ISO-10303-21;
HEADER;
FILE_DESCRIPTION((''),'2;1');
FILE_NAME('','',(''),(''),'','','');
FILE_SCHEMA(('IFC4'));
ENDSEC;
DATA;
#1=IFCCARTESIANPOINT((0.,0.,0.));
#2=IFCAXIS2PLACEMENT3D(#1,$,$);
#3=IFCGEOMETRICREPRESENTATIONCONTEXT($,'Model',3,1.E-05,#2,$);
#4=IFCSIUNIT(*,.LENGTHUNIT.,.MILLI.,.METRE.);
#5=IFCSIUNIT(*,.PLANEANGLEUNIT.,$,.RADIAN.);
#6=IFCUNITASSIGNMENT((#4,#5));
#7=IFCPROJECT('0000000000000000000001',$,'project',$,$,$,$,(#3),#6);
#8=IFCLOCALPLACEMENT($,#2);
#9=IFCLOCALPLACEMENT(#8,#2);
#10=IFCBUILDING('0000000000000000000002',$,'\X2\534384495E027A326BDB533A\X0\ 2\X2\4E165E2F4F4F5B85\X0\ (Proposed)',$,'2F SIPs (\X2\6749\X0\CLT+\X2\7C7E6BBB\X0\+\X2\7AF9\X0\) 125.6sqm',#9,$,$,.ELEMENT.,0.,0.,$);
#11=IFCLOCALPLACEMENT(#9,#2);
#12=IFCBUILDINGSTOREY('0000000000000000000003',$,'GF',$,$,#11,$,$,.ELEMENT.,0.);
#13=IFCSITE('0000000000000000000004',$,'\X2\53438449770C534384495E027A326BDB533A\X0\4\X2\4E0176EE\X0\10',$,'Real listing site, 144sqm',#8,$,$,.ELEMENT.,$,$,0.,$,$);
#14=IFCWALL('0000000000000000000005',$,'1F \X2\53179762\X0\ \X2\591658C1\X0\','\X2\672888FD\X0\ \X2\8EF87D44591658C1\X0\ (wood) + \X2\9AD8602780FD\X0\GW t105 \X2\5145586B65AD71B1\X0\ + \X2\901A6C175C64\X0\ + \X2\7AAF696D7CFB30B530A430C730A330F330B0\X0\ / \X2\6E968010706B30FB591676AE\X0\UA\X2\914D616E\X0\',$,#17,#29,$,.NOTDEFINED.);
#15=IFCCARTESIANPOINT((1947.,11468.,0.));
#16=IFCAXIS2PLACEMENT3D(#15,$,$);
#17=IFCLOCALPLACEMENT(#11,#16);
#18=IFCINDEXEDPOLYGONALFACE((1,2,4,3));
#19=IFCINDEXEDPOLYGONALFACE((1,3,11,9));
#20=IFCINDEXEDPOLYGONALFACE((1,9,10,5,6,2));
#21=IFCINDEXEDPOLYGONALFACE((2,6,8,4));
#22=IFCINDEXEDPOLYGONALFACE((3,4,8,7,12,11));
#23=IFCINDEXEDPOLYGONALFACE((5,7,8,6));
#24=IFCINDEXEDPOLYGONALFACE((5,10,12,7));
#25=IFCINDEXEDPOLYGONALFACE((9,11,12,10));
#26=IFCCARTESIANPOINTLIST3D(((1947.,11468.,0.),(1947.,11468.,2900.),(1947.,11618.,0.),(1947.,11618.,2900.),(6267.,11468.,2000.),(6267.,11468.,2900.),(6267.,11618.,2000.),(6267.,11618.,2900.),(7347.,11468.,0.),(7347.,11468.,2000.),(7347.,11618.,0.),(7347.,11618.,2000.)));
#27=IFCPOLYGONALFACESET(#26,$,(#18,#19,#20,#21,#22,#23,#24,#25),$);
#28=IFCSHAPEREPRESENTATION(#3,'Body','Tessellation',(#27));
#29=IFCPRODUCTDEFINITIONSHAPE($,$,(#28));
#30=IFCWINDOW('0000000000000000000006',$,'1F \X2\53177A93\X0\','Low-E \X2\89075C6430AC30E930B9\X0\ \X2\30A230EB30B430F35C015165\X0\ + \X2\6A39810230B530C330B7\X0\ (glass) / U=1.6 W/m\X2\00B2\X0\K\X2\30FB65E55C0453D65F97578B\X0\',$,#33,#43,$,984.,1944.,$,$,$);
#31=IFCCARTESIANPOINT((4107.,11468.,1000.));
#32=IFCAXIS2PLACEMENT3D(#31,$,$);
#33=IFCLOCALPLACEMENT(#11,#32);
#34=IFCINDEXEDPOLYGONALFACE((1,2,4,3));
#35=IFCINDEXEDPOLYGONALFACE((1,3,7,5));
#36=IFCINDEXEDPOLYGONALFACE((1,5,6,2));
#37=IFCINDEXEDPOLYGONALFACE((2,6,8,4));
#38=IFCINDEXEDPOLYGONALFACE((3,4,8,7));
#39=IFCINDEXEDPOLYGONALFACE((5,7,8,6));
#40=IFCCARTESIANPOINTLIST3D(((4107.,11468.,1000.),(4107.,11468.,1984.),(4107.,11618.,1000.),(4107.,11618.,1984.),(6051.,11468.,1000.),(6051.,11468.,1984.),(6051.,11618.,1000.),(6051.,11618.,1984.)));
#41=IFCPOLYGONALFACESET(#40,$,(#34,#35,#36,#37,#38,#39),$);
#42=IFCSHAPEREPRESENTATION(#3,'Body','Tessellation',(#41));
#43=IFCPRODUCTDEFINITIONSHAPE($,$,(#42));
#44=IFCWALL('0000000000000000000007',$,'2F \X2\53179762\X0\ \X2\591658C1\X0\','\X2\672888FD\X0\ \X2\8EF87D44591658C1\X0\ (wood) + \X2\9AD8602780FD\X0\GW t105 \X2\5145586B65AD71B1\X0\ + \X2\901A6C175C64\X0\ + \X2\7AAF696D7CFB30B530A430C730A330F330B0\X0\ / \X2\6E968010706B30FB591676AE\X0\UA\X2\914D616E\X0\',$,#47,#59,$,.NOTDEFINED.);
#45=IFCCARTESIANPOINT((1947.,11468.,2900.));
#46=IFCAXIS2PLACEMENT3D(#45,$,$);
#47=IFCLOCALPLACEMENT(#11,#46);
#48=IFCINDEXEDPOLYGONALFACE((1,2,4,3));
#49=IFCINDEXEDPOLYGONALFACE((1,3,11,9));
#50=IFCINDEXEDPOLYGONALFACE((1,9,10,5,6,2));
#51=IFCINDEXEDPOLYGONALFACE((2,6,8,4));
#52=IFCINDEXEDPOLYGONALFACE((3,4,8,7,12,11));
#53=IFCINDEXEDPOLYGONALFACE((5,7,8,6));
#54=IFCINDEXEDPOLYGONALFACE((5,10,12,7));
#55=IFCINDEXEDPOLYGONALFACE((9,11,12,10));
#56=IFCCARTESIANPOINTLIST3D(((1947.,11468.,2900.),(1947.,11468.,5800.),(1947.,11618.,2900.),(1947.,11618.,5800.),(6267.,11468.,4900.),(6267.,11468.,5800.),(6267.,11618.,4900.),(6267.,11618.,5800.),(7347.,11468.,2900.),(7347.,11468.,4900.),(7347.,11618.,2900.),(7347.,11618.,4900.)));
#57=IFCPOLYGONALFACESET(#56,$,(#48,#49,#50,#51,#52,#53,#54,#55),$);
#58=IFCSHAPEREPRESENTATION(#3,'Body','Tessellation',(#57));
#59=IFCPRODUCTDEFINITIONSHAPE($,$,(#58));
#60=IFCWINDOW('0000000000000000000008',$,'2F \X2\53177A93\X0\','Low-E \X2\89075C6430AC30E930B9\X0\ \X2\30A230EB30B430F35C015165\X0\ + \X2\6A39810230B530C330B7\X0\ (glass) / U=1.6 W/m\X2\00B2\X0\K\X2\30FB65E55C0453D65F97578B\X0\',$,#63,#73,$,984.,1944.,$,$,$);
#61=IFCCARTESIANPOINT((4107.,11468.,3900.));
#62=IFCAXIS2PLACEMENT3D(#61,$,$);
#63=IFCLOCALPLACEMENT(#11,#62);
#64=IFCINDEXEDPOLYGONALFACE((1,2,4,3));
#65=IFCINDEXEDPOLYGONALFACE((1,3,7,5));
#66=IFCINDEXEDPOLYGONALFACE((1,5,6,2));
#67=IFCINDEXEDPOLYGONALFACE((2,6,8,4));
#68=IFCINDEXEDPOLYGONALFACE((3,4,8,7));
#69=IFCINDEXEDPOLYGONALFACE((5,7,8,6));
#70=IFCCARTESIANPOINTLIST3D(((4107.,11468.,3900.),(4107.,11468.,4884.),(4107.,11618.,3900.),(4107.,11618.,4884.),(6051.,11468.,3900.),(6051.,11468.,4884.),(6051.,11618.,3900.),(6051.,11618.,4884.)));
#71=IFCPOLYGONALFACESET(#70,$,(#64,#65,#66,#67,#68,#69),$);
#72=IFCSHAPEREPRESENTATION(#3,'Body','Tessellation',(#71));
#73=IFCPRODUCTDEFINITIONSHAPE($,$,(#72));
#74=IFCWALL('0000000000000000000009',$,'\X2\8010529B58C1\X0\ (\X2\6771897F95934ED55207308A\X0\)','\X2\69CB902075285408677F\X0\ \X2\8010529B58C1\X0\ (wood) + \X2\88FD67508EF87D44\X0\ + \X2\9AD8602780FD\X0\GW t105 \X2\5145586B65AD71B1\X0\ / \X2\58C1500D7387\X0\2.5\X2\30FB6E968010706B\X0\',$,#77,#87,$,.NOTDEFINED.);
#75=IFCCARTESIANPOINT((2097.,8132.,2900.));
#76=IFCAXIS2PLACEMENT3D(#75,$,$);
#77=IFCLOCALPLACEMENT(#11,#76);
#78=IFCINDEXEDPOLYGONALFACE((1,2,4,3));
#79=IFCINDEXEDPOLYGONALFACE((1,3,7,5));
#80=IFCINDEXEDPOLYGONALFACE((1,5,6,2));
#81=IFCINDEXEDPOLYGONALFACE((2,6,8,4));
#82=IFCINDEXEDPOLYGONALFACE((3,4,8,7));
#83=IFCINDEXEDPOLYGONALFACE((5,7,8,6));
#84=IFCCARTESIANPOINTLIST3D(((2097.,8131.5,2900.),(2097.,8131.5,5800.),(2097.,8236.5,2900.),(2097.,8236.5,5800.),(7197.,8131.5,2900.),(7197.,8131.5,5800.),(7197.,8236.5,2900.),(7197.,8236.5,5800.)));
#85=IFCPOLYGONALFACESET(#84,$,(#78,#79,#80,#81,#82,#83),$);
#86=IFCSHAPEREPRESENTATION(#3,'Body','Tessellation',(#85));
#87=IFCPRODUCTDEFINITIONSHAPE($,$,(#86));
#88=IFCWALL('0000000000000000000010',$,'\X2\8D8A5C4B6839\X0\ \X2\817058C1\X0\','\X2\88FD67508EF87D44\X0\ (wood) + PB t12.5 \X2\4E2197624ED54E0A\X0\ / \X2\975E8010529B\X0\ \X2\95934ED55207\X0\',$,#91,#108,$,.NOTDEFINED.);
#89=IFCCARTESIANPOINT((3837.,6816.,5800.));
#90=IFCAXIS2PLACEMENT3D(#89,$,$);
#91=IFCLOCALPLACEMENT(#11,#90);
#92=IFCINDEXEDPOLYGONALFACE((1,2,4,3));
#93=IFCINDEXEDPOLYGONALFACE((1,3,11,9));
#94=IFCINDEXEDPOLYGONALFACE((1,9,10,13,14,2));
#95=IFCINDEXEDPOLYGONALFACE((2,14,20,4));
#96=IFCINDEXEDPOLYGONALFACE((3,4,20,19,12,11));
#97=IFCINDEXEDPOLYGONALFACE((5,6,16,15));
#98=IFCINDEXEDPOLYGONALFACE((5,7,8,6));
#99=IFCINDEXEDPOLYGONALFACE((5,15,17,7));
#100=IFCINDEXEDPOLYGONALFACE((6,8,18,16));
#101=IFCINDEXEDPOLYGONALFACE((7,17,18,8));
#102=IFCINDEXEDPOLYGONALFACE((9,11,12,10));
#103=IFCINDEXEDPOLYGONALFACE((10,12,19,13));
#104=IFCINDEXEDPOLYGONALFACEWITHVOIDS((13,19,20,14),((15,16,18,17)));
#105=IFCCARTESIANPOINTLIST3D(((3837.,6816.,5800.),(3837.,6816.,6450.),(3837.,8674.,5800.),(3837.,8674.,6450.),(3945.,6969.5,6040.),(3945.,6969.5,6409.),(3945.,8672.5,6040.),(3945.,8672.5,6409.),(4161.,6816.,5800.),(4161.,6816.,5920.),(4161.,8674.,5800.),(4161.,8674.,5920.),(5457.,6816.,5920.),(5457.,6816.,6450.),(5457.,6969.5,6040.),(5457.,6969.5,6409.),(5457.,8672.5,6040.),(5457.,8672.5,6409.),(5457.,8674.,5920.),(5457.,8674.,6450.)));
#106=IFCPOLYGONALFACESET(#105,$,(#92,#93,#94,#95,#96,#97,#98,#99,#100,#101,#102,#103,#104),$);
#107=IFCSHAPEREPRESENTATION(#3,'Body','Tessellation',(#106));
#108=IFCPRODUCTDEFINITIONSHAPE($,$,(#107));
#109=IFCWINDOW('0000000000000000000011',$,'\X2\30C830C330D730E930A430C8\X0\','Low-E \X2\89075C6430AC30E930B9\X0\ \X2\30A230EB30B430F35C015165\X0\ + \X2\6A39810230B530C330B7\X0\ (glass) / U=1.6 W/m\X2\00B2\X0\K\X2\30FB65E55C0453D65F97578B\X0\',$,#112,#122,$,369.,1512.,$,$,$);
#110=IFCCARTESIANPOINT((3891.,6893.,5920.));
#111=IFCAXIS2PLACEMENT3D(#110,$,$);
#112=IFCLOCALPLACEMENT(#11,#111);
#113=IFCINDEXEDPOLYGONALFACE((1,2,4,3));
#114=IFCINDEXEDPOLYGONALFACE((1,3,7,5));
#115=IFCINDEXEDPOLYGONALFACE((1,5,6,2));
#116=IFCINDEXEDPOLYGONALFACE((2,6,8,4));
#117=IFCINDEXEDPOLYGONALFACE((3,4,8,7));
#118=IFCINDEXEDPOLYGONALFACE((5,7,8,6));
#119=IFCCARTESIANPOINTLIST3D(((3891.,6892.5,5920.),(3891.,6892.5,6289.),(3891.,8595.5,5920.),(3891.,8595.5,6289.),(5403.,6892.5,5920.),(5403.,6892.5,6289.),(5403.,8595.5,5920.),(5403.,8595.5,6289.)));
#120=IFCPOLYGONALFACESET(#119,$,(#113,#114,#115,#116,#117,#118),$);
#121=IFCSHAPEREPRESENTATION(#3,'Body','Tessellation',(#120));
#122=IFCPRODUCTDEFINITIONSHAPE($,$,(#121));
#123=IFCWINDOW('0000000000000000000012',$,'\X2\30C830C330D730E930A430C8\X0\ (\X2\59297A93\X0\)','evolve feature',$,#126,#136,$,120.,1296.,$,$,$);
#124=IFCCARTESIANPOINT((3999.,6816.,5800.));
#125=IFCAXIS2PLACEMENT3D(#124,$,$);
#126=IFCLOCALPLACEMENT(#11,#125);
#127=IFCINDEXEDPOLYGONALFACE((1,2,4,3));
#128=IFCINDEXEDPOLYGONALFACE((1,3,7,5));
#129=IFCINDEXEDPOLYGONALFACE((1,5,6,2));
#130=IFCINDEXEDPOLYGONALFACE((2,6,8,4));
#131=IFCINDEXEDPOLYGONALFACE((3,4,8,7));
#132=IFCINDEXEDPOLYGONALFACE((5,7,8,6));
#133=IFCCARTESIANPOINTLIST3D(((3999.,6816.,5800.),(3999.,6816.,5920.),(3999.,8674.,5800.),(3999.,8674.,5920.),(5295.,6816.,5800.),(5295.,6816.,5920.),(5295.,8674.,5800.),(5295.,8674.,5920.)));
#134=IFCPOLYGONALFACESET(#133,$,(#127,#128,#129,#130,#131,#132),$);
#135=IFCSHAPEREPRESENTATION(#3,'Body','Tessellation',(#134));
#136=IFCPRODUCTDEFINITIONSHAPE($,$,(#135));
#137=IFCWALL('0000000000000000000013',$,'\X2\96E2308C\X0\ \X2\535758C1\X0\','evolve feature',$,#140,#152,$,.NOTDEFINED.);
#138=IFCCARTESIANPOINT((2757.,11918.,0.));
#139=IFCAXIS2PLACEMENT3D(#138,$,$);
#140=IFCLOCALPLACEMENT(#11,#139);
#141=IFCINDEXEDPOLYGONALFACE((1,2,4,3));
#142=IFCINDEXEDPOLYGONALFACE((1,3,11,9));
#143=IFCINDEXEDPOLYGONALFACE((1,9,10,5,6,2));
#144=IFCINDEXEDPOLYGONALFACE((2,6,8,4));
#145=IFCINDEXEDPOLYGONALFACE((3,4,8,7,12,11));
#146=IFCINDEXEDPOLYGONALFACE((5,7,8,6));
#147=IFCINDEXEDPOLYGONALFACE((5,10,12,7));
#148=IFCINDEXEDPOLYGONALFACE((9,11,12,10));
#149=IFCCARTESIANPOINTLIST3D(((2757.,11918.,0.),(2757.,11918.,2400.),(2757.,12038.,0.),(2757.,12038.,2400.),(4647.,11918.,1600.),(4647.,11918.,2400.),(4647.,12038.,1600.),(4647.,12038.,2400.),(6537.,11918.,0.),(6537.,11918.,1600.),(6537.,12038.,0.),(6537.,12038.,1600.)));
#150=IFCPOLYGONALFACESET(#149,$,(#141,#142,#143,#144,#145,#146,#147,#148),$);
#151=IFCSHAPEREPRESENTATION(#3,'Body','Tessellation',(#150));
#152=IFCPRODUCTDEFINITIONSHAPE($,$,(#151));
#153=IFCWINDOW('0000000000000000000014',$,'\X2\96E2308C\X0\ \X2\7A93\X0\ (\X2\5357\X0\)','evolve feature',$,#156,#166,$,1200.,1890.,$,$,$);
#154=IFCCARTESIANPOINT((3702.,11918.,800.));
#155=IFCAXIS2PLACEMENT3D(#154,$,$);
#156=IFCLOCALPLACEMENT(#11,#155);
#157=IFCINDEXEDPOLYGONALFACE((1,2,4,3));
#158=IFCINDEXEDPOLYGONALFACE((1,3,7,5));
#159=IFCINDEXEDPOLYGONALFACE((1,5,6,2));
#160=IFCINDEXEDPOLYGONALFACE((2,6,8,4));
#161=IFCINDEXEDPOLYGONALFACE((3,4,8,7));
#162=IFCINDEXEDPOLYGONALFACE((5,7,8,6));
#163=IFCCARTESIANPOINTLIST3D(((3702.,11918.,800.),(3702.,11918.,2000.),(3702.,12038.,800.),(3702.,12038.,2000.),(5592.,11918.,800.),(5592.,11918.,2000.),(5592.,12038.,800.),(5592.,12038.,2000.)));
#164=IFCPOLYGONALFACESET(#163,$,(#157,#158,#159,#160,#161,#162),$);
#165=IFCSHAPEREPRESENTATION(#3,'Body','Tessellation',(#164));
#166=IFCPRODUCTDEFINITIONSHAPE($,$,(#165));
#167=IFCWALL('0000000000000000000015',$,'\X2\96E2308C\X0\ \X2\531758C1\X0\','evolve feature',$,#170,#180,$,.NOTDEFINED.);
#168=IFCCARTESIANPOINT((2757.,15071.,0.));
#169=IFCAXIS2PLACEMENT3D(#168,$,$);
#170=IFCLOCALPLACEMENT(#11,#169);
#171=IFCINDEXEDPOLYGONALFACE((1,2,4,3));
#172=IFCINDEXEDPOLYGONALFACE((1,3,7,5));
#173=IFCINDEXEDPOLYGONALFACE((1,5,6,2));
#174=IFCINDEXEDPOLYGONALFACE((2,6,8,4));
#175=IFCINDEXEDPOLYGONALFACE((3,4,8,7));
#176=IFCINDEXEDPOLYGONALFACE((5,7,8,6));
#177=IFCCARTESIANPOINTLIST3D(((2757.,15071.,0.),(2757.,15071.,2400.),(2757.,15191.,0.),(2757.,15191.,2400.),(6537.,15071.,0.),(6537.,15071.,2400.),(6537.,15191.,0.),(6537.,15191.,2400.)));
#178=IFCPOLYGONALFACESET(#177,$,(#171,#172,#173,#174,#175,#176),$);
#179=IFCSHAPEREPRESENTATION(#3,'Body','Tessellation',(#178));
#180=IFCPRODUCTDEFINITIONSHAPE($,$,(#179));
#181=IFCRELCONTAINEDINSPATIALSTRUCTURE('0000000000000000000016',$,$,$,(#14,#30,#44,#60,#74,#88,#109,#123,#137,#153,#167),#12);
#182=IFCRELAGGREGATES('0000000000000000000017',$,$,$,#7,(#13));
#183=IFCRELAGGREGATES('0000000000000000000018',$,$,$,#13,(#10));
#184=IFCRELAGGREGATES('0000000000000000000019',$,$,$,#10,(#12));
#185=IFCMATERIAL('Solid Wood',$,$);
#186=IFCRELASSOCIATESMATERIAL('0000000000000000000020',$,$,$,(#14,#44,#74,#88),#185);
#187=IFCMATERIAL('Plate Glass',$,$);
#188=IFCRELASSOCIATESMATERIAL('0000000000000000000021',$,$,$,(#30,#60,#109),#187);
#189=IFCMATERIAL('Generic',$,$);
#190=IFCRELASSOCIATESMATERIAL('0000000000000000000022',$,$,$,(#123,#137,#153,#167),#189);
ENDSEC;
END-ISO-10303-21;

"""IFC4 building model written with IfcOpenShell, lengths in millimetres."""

from ifc_helpers import new_model, si_unit, frame, frame_2d, origin, place, context, project, spatial, rectangle, extrude, material, element, fill, save


model = new_model("IFC4")

# Units and contexts
model_context = context("Model", 3, precision=1e-05, world=origin())
ifc_project = project(units=[si_unit("LENGTHUNIT", "METRE", prefix="MILLI"), si_unit("PLANEANGLEUNIT", "RADIAN")], contexts=[model_context])

# Site, building, storey
site_placement = place(None, origin())
site = spatial("IfcSite", under=ifc_project, at=site_placement, Name="千葉県千葉市稲毛区4丁目10", ObjectType="Real listing site, 144sqm", CompositionType="ELEMENT", RefElevation=0.0)
building_placement = place(site_placement, origin())
building = spatial("IfcBuilding", under=site, at=building_placement, Name="千葉市稲毛区 2世帯住宅 (Proposed)", ObjectType="2F SIPs (杉CLT+籾殻+竹) 125.6sqm", CompositionType="ELEMENT", ElevationOfRefHeight=0.0, ElevationOfTerrain=0.0)
storey_placement = place(building_placement, origin())
storey = spatial("IfcBuildingStorey", under=building, at=storey_placement, Name="GF", CompositionType="ELEMENT", Elevation=0.0)

# Shared definitions
ifc_material_1 = material(Name="Generic")

# Wall, opening, window
ifc_material_2 = material(Name="Solid Wood")
wall_1_placement = place(storey_placement, frame((1947.0, 11468.0, 0.0)))
wall_1 = element("IfcWall", 1, at=wall_1_placement, inside=storey, material=ifc_material_2, Name="1F 北面 外壁", Description="木製 軸組外壁 (wood) + 高性能GW t105 充填断熱 + 通気層 + 窯業系サイディング / 準耐火・外皮UA配慮", PredefinedType="NOTDEFINED", context=model_context, shape_type="SweptSolid", body=[
    extrude(rectangle(XDim=5400.0, YDim=150.0, at=frame_2d((2700.0, 75.0))), frame((1947.0, 11468.0, 0.0)), (0.0, 0.0, 1.0), 2900.0),
])
opening_1_placement = place(storey_placement, frame((4107.0, 11468.0, 1000.0)))
opening_1 = element("IfcOpeningElement", 2, at=opening_1_placement, cuts=wall_1, PredefinedType="NOTDEFINED", context=model_context, shape_type="SweptSolid", body=[
    extrude(rectangle(XDim=1944.0, YDim=150.0, at=frame_2d((972.0, 75.0))), frame((4107.0, 11468.0, 1000.0)), (0.0, 0.0, 1.0), 984.0),
])
ifc_material_3 = material(Name="Plate Glass")
window_1_placement = place(storey_placement, frame((4107.0, 11468.0, 1000.0)))
window_1 = element("IfcWindow", 3, at=window_1_placement, inside=storey, material=ifc_material_3, Name="1F 北窓", Description="Low-E 複層ガラス アルゴン封入 + 樹脂サッシ (glass) / U=1.6 W/m²K・日射取得型", OverallHeight=984.0, OverallWidth=1944.0, context=model_context, shape_type="SweptSolid", body=[
    extrude(rectangle(XDim=1944.0, YDim=150.0, at=frame_2d((972.0, 75.0))), frame((4107.0, 11468.0, 1000.0)), (0.0, 0.0, 1.0), 984.0),
])
fill(opening_1, window_1)

# Wall, opening, window
wall_2_placement = place(storey_placement, frame((1947.0, 11468.0, 2900.0)))
wall_2 = element("IfcWall", 4, at=wall_2_placement, inside=storey, material=ifc_material_2, Name="2F 北面 外壁", Description="木製 軸組外壁 (wood) + 高性能GW t105 充填断熱 + 通気層 + 窯業系サイディング / 準耐火・外皮UA配慮", PredefinedType="NOTDEFINED", context=model_context, shape_type="SweptSolid", body=[
    extrude(rectangle(XDim=5400.0, YDim=150.0, at=frame_2d((2700.0, 75.0))), frame((1947.0, 11468.0, 2900.0)), (0.0, 0.0, 1.0), 2900.0),
])
opening_2_placement = place(storey_placement, frame((4107.0, 11468.0, 3900.0)))
opening_2 = element("IfcOpeningElement", 5, at=opening_2_placement, cuts=wall_2, PredefinedType="NOTDEFINED", context=model_context, shape_type="SweptSolid", body=[
    extrude(rectangle(XDim=1944.0, YDim=150.0, at=frame_2d((972.0, 75.0))), frame((4107.0, 11468.0, 3900.0)), (0.0, 0.0, 1.0), 984.0),
])
window_2_placement = place(storey_placement, frame((4107.0, 11468.0, 3900.0)))
window_2 = element("IfcWindow", 6, at=window_2_placement, inside=storey, material=ifc_material_3, Name="2F 北窓", Description="Low-E 複層ガラス アルゴン封入 + 樹脂サッシ (glass) / U=1.6 W/m²K・日射取得型", OverallHeight=984.0, OverallWidth=1944.0, context=model_context, shape_type="SweptSolid", body=[
    extrude(rectangle(XDim=1944.0, YDim=150.0, at=frame_2d((972.0, 75.0))), frame((4107.0, 11468.0, 3900.0)), (0.0, 0.0, 1.0), 984.0),
])
fill(opening_2, window_2)

# Wall
wall_3_placement = place(storey_placement, frame((2097.0, 8132.0, 2900.0)))
element("IfcWall", 7, at=wall_3_placement, inside=storey, material=ifc_material_2, Name="耐力壁 (東西間仕切り)", Description="構造用合板 耐力壁 (wood) + 製材軸組 + 高性能GW t105 充填断熱 / 壁倍率2.5・準耐火", PredefinedType="NOTDEFINED", context=model_context, shape_type="SweptSolid", body=[
    extrude(rectangle(XDim=5100.0, YDim=105.0, at=frame_2d((2550.0, 52.0))), frame((2097.0, 8132.0, 2900.0)), (0.0, 0.0, 1.0), 2900.0),
])

# Wall, openings, windows
wall_4_placement = place(storey_placement, frame((3837.0, 6816.0, 5800.0)))
wall_4 = element("IfcWall", 8, at=wall_4_placement, inside=storey, material=ifc_material_2, Name="越屋根 腰壁", Description="製材軸組 (wood) + PB t12.5 両面仕上 / 非耐力 間仕切", PredefinedType="NOTDEFINED", context=model_context, shape_type="SweptSolid", body=[
    extrude(rectangle(XDim=1620.0, YDim=1858.0, at=frame_2d((810.0, 929.0))), frame((3837.0, 6816.0, 5800.0)), (0.0, 0.0, 1.0), 650.0),
])
opening_3_placement = place(storey_placement, frame((3891.0, 6893.0, 5920.0)))
opening_3 = element("IfcOpeningElement", 9, at=opening_3_placement, cuts=wall_4, PredefinedType="NOTDEFINED", context=model_context, shape_type="SweptSolid", body=[
    extrude(rectangle(XDim=1512.0, YDim=1703.0, at=frame_2d((756.0, 851.0))), frame((3891.0, 6893.0, 5920.0)), (0.0, 0.0, 1.0), 369.0),
])
opening_4_placement = place(storey_placement, frame((3999.0, 6816.0, 5800.0)))
opening_4 = element("IfcOpeningElement", 10, at=opening_4_placement, cuts=wall_4, PredefinedType="NOTDEFINED", context=model_context, shape_type="SweptSolid", body=[
    extrude(rectangle(XDim=1296.0, YDim=1858.0, at=frame_2d((648.0, 929.0))), frame((3999.0, 6816.0, 5800.0)), (0.0, 0.0, 1.0), 120.0),
])
window_3_placement = place(storey_placement, frame((3891.0, 6893.0, 5920.0)))
window_3 = element("IfcWindow", 11, at=window_3_placement, inside=storey, material=ifc_material_3, Name="トップライト", Description="Low-E 複層ガラス アルゴン封入 + 樹脂サッシ (glass) / U=1.6 W/m²K・日射取得型", OverallHeight=369.0, OverallWidth=1512.0, context=model_context, shape_type="SweptSolid", body=[
    extrude(rectangle(XDim=1512.0, YDim=1703.0, at=frame_2d((756.0, 851.0))), frame((3891.0, 6893.0, 5920.0)), (0.0, 0.0, 1.0), 369.0),
])
fill(opening_3, window_3)
window_4_placement = place(storey_placement, frame((3999.0, 6816.0, 5800.0)))
window_4 = element("IfcWindow", 12, at=window_4_placement, inside=storey, material=ifc_material_1, Name="トップライト (天窓)", Description="evolve feature", OverallHeight=120.0, OverallWidth=1296.0, context=model_context, shape_type="SweptSolid", body=[
    extrude(rectangle(XDim=1296.0, YDim=1858.0, at=frame_2d((648.0, 929.0))), frame((3999.0, 6816.0, 5800.0)), (0.0, 0.0, 1.0), 120.0),
])
fill(opening_4, window_4)

# Wall, opening, window
wall_5_placement = place(storey_placement, frame((2757.0, 11918.0, 0.0)))
wall_5 = element("IfcWall", 13, at=wall_5_placement, inside=storey, material=ifc_material_1, Name="離れ 南壁", Description="evolve feature", PredefinedType="NOTDEFINED", context=model_context, shape_type="SweptSolid", body=[
    extrude(rectangle(XDim=3780.0, YDim=120.0, at=frame_2d((1890.0, 60.0))), frame((2757.0, 11918.0, 0.0)), (0.0, 0.0, 1.0), 2400.0),
])
opening_5_placement = place(storey_placement, frame((3702.0, 11918.0, 800.0)))
opening_5 = element("IfcOpeningElement", 14, at=opening_5_placement, cuts=wall_5, PredefinedType="NOTDEFINED", context=model_context, shape_type="SweptSolid", body=[
    extrude(rectangle(XDim=1890.0, YDim=120.0, at=frame_2d((945.0, 60.0))), frame((3702.0, 11918.0, 800.0)), (0.0, 0.0, 1.0), 1200.0),
])
window_5_placement = place(storey_placement, frame((3702.0, 11918.0, 800.0)))
window_5 = element("IfcWindow", 15, at=window_5_placement, inside=storey, material=ifc_material_1, Name="離れ 窓 (南)", Description="evolve feature", OverallHeight=1200.0, OverallWidth=1890.0, context=model_context, shape_type="SweptSolid", body=[
    extrude(rectangle(XDim=1890.0, YDim=120.0, at=frame_2d((945.0, 60.0))), frame((3702.0, 11918.0, 800.0)), (0.0, 0.0, 1.0), 1200.0),
])
fill(opening_5, window_5)

# Wall
wall_6_placement = place(storey_placement, frame((2757.0, 15071.0, 0.0)))
element("IfcWall", 16, at=wall_6_placement, inside=storey, material=ifc_material_1, Name="離れ 北壁", Description="evolve feature", PredefinedType="NOTDEFINED", context=model_context, shape_type="SweptSolid", body=[
    extrude(rectangle(XDim=3780.0, YDim=120.0, at=frame_2d((1890.0, 60.0))), frame((2757.0, 15071.0, 0.0)), (0.0, 0.0, 1.0), 2400.0),
])

save(model, "model.ifc")
